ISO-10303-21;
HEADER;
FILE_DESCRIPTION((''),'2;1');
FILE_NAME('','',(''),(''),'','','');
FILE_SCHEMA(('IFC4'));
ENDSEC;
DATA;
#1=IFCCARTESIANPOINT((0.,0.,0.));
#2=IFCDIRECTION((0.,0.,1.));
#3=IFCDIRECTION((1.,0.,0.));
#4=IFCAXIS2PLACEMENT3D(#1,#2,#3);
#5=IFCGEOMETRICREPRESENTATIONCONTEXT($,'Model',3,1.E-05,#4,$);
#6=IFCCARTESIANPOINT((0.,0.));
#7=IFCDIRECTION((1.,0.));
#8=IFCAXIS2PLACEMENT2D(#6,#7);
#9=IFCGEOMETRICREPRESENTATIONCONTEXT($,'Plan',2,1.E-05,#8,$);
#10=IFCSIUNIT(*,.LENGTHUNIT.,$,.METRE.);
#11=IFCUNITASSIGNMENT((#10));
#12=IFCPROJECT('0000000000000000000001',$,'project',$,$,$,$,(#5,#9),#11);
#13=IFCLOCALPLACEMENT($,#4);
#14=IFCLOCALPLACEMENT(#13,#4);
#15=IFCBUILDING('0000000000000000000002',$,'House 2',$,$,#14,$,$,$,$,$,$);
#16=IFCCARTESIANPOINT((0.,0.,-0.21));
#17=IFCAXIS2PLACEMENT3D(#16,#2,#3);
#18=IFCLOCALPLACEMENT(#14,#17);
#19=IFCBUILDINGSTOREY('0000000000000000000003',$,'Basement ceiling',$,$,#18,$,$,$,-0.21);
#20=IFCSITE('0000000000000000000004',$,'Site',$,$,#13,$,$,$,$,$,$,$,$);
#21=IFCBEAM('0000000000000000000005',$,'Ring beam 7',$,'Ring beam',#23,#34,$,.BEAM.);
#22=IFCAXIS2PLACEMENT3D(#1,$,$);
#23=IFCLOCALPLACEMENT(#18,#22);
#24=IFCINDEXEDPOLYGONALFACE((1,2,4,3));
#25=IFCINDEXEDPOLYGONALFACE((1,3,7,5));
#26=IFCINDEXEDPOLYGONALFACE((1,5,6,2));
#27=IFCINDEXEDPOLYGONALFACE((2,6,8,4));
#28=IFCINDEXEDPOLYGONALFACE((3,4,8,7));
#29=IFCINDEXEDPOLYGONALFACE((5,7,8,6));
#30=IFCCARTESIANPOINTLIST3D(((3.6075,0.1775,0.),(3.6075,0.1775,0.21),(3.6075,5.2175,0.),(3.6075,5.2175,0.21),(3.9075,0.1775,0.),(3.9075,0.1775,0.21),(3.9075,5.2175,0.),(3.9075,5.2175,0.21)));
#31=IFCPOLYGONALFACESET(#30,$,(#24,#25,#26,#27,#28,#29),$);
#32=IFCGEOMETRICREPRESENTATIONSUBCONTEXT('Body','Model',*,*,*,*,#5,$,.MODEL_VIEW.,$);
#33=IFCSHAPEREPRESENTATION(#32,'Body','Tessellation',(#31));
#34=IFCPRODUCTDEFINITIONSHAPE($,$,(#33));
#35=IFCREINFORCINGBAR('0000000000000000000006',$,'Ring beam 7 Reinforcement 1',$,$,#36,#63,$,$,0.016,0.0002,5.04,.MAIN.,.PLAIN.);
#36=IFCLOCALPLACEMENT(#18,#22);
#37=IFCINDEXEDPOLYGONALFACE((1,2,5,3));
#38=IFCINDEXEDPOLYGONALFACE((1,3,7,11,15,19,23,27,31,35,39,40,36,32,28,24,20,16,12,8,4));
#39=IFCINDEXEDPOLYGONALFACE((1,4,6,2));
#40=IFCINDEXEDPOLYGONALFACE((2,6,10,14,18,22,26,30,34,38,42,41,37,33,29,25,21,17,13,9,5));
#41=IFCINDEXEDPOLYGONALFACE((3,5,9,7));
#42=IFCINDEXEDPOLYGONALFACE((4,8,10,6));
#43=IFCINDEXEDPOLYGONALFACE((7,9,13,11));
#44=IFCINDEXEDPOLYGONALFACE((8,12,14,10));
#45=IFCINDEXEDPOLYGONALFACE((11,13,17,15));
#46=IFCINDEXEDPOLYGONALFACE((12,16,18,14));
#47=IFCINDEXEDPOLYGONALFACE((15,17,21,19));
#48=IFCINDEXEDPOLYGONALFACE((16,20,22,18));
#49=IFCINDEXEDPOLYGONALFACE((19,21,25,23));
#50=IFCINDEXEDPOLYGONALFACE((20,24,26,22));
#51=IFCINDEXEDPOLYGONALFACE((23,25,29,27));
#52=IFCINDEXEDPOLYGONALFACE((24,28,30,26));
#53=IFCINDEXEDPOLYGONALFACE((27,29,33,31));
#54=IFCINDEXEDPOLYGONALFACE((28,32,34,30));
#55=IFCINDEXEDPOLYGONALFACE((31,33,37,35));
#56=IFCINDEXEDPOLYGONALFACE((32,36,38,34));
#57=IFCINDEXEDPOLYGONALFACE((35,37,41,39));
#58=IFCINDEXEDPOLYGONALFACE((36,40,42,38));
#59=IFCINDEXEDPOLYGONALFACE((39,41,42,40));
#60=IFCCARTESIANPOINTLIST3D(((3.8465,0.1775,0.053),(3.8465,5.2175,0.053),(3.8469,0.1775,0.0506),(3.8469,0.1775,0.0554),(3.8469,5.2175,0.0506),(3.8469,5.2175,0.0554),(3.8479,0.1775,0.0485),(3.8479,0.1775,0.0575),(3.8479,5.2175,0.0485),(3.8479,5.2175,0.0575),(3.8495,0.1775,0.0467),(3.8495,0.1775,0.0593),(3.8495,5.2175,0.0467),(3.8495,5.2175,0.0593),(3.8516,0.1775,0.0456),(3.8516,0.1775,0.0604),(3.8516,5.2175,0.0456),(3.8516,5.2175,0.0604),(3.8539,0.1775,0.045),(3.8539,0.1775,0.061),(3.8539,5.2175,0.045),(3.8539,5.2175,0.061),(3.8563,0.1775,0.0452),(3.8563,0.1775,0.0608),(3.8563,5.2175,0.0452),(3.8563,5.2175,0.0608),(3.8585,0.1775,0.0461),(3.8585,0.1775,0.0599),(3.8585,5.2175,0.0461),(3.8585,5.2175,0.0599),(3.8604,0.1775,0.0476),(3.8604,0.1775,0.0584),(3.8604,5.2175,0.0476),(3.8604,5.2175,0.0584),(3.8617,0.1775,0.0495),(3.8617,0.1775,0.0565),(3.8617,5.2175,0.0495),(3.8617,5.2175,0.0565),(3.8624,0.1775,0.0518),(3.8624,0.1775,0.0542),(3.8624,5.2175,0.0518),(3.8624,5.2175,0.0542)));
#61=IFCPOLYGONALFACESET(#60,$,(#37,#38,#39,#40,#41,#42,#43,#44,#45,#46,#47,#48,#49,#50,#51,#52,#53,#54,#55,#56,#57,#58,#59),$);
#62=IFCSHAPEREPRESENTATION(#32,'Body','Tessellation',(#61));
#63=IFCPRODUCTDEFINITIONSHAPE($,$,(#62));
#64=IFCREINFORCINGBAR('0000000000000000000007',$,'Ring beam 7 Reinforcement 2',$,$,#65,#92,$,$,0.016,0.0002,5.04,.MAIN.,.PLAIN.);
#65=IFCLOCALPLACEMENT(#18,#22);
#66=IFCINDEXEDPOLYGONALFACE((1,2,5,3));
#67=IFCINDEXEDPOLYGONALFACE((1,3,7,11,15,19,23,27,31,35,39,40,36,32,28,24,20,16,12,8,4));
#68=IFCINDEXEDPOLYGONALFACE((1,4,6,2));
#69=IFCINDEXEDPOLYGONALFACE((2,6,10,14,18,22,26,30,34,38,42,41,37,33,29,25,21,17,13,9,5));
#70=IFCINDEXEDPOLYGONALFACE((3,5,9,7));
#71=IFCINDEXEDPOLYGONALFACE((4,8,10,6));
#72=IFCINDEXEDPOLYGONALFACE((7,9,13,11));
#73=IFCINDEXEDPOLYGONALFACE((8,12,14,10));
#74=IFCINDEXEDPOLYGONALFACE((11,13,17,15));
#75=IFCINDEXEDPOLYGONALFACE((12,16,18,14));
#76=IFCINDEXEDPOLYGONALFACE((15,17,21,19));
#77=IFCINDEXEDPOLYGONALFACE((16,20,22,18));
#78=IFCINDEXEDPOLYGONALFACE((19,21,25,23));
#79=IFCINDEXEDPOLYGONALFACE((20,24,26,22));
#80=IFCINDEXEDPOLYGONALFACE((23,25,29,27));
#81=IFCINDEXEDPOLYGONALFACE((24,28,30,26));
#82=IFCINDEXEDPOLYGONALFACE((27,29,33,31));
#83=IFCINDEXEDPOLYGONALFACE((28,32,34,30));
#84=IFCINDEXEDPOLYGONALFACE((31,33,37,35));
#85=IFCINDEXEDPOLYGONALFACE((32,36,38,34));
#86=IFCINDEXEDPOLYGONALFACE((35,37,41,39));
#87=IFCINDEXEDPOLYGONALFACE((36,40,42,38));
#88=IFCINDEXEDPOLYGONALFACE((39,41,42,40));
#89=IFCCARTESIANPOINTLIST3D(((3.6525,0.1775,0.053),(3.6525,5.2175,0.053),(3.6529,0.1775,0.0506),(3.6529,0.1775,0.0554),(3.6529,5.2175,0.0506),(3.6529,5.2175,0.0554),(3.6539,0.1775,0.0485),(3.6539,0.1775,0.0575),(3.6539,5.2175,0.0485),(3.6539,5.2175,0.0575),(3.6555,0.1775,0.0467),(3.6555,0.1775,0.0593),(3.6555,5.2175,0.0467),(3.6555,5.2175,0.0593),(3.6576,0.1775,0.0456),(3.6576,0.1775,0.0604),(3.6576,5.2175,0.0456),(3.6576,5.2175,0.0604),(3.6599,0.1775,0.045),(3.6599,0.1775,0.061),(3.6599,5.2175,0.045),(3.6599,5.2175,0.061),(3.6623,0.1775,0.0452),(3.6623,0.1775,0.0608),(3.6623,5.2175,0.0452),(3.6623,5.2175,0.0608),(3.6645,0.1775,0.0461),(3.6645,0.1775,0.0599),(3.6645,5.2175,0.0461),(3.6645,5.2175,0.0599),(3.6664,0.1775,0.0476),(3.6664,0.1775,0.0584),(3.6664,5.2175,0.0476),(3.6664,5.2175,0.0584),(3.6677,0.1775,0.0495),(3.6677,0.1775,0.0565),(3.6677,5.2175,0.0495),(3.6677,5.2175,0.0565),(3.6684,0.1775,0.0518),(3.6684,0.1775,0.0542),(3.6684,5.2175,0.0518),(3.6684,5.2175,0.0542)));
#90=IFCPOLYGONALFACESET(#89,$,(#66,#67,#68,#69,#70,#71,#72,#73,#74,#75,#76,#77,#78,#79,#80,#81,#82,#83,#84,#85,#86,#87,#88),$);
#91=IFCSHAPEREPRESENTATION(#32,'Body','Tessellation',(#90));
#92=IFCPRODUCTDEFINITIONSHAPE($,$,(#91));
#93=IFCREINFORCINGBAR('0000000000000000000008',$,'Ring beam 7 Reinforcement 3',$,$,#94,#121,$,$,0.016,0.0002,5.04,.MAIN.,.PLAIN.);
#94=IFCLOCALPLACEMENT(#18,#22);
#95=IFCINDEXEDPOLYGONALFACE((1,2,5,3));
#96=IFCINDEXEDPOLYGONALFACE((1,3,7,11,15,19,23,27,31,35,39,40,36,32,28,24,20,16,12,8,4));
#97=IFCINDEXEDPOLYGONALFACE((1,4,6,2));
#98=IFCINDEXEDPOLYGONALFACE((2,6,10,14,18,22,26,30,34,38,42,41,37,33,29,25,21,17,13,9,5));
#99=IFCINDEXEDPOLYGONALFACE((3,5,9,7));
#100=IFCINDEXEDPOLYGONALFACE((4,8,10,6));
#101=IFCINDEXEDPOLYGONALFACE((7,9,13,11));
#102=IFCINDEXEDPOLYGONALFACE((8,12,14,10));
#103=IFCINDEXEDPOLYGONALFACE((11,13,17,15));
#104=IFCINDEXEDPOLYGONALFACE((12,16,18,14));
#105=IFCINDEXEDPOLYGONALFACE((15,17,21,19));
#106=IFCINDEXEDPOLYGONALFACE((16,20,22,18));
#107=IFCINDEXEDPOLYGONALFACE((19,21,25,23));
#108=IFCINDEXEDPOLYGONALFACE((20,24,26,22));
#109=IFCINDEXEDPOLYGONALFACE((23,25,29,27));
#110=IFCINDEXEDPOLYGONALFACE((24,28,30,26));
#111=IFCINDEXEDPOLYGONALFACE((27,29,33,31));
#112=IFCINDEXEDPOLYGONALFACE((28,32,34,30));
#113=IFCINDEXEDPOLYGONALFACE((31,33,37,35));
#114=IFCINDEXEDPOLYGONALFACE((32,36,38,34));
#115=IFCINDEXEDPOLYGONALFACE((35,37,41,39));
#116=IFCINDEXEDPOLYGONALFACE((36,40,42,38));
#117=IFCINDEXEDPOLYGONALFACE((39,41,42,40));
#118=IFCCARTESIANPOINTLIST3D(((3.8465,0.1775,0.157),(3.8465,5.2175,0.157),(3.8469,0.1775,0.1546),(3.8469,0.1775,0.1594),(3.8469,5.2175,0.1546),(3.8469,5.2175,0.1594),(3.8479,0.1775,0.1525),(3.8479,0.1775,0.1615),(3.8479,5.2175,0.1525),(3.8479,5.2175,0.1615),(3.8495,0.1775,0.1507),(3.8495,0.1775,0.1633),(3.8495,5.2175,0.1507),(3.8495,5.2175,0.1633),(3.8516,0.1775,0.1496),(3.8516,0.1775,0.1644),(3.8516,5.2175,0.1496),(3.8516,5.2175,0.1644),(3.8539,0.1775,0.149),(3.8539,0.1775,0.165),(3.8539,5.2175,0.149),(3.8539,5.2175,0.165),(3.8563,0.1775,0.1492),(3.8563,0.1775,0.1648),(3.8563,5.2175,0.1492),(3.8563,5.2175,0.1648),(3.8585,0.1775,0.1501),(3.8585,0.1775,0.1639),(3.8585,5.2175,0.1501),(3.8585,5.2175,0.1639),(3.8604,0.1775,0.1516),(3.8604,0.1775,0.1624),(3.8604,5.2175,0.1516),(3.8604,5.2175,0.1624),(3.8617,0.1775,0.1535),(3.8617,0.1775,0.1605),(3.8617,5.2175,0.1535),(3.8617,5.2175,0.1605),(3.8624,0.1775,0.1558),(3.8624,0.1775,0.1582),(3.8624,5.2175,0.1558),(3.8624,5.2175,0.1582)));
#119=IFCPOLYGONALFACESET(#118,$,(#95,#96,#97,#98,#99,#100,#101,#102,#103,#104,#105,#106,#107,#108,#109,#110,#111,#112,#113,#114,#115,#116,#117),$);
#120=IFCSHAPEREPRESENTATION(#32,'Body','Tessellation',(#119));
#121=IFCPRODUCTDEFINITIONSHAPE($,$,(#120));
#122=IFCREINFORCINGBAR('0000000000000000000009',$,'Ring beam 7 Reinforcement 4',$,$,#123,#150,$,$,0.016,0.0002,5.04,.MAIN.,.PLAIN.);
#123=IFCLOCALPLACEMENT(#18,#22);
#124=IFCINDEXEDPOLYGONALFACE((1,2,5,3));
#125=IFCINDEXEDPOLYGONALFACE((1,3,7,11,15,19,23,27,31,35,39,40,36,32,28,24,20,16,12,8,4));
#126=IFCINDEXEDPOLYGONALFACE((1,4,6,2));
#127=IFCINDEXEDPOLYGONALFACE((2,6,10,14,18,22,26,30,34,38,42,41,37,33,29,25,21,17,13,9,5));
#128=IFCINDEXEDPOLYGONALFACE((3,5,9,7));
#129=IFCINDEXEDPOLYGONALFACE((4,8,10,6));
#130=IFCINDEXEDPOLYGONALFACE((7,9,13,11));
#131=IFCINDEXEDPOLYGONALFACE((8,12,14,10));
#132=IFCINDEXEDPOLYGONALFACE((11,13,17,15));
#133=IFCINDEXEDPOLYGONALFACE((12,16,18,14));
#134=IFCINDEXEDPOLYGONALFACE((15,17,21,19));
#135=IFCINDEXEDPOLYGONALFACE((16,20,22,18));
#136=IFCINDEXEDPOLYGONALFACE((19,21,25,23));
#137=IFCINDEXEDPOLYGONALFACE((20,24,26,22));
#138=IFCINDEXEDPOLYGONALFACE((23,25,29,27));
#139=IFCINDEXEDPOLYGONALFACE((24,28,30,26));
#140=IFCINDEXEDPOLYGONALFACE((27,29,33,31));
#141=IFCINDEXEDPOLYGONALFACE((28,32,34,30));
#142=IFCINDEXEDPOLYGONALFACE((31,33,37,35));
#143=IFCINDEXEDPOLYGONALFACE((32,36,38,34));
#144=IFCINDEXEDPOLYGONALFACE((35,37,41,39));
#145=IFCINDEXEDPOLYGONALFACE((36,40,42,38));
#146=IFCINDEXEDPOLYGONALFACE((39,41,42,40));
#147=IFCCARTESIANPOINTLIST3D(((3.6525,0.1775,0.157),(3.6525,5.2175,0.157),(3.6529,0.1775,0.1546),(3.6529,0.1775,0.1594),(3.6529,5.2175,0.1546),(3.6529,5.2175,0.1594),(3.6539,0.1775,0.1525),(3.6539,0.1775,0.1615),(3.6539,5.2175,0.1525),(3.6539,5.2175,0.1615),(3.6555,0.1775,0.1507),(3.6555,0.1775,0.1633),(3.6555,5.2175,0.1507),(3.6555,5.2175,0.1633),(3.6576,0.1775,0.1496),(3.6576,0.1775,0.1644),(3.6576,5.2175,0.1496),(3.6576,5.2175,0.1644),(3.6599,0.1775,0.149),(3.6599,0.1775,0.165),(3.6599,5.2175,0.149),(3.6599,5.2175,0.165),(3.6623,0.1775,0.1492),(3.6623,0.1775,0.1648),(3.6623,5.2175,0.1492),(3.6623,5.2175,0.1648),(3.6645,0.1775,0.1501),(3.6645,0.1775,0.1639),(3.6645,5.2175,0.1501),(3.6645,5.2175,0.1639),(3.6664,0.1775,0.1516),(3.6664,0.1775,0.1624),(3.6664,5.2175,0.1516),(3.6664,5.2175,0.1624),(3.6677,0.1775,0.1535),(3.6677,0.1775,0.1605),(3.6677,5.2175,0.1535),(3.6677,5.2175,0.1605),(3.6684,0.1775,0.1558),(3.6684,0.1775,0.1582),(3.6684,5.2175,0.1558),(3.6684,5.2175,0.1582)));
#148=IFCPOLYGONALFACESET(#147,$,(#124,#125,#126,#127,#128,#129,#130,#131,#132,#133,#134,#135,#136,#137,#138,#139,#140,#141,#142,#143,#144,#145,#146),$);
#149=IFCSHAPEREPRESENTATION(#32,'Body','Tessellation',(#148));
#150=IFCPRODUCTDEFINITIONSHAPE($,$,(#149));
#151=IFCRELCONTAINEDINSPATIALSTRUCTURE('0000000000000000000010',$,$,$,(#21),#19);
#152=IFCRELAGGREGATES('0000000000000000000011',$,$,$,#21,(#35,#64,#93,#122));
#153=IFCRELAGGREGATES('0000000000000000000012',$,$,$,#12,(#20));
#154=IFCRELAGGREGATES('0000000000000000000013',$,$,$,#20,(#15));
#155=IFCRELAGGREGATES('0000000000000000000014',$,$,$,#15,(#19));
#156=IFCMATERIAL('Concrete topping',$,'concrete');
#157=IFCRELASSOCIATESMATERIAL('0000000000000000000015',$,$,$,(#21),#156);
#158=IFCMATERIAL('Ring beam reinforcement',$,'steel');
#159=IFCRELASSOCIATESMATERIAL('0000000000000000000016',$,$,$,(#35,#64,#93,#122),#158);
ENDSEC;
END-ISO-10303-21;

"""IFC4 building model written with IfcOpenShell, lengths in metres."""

from ifc_helpers import new_model, si_unit, frame, origin_with_axes, origin_2d, origin_2d_with_axis, place, context, subcontext, project, spatial, circle_curve, rectangle, outline, extrude, material, element, aggregate, save


model = new_model("IFC4")

# Units and contexts
model_context = context("Model", 3, precision=1e-05, world=origin_with_axes())
plan_context = context("Plan", 2, precision=1e-05, world=origin_2d_with_axis())
body_context = subcontext(model_context, "Body", "Model", "MODEL_VIEW")
ifc_project = project(units=[si_unit("LENGTHUNIT", "METRE")], contexts=[model_context, plan_context])

# Site, building, storey
site_placement = place(None, origin_with_axes())
site = spatial("IfcSite", under=ifc_project, at=site_placement, Name="Site")
building_placement = place(site_placement, origin_with_axes())
building = spatial("IfcBuilding", under=site, at=building_placement, Name="House 2")
storey_placement = place(building_placement, frame((0.0, 0.0, -0.21), z_axis=(0.0, 0.0, 1.0), x_axis=(1.0, 0.0, 0.0)))
storey = spatial("IfcBuildingStorey", under=building, at=storey_placement, Name="Basement ceiling", Elevation=-0.21)

# Beam
ifc_material_1 = material(Name="Concrete topping", Category="concrete")
beam_1_placement = place(storey_placement, frame((3.7575, 0.1775, 0.105), z_axis=(0.0, 0.0, 1.0), x_axis=(0.0, 1.0, 0.0)))
beam_1 = element("IfcBeam", 1, at=beam_1_placement, inside=storey, material=ifc_material_1, Name="Ring beam 7", ObjectType="Ring beam", PredefinedType="BEAM", context=body_context, shape_type="SweptSolid", body=[
    extrude(rectangle(XDim=0.3, YDim=0.21), frame((0.0, 0.0, 0.0), z_axis=(1.0, 0.0, 0.0), x_axis=(0.0, 1.0, 0.0)), (0.0, 0.0, 1.0), 5.04),
])

# Reinforcing bars
ifc_material_2 = material(Name="Ring beam reinforcement", Category="steel")
reinforcing_bar_1_placement = place(beam_1_placement, frame((0.0, -0.097, -0.052), z_axis=(0.0, 0.0, 1.0), x_axis=(1.0, 0.0, 0.0)))
reinforcing_bar_1 = element("IfcReinforcingBar", 2, at=reinforcing_bar_1_placement, material=ifc_material_2, Name="Ring beam 7 Reinforcement 1", BarLength=5.04, BarSurface="PLAIN", CrossSectionArea=0.0002, NominalDiameter=0.016, PredefinedType="MAIN", context=body_context, shape_type="SweptSolid", body=[
    extrude(outline(circle_curve(origin_2d(), 0.008)), frame((0.0, 0.0, 0.0), z_axis=(1.0, 0.0, 0.0), x_axis=(0.0, 1.0, 0.0)), (0.0, 0.0, 1.0), 5.04),
])
reinforcing_bar_2_placement = place(beam_1_placement, frame((0.0, 0.097, -0.052), z_axis=(0.0, 0.0, 1.0), x_axis=(1.0, 0.0, 0.0)))
reinforcing_bar_2 = element("IfcReinforcingBar", 3, at=reinforcing_bar_2_placement, material=ifc_material_2, Name="Ring beam 7 Reinforcement 2", BarLength=5.04, BarSurface="PLAIN", CrossSectionArea=0.0002, NominalDiameter=0.016, PredefinedType="MAIN", context=body_context, shape_type="SweptSolid", body=[
    extrude(outline(circle_curve(origin_2d(), 0.008)), frame((0.0, 0.0, 0.0), z_axis=(1.0, 0.0, 0.0), x_axis=(0.0, 1.0, 0.0)), (0.0, 0.0, 1.0), 5.04),
])
reinforcing_bar_3_placement = place(beam_1_placement, frame((0.0, -0.097, 0.052), z_axis=(0.0, 0.0, 1.0), x_axis=(1.0, 0.0, 0.0)))
reinforcing_bar_3 = element("IfcReinforcingBar", 4, at=reinforcing_bar_3_placement, material=ifc_material_2, Name="Ring beam 7 Reinforcement 3", BarLength=5.04, BarSurface="PLAIN", CrossSectionArea=0.0002, NominalDiameter=0.016, PredefinedType="MAIN", context=body_context, shape_type="SweptSolid", body=[
    extrude(outline(circle_curve(origin_2d(), 0.008)), frame((0.0, 0.0, 0.0), z_axis=(1.0, 0.0, 0.0), x_axis=(0.0, 1.0, 0.0)), (0.0, 0.0, 1.0), 5.04),
])
reinforcing_bar_4_placement = place(beam_1_placement, frame((0.0, 0.097, 0.052), z_axis=(0.0, 0.0, 1.0), x_axis=(1.0, 0.0, 0.0)))
reinforcing_bar_4 = element("IfcReinforcingBar", 5, at=reinforcing_bar_4_placement, material=ifc_material_2, Name="Ring beam 7 Reinforcement 4", BarLength=5.04, BarSurface="PLAIN", CrossSectionArea=0.0002, NominalDiameter=0.016, PredefinedType="MAIN", context=body_context, shape_type="SweptSolid", body=[
    extrude(outline(circle_curve(origin_2d(), 0.008)), frame((0.0, 0.0, 0.0), z_axis=(1.0, 0.0, 0.0), x_axis=(0.0, 1.0, 0.0)), (0.0, 0.0, 1.0), 5.04),
])
aggregate(beam_1, [reinforcing_bar_1, reinforcing_bar_2, reinforcing_bar_3, reinforcing_bar_4])

save(model, "model.ifc")
